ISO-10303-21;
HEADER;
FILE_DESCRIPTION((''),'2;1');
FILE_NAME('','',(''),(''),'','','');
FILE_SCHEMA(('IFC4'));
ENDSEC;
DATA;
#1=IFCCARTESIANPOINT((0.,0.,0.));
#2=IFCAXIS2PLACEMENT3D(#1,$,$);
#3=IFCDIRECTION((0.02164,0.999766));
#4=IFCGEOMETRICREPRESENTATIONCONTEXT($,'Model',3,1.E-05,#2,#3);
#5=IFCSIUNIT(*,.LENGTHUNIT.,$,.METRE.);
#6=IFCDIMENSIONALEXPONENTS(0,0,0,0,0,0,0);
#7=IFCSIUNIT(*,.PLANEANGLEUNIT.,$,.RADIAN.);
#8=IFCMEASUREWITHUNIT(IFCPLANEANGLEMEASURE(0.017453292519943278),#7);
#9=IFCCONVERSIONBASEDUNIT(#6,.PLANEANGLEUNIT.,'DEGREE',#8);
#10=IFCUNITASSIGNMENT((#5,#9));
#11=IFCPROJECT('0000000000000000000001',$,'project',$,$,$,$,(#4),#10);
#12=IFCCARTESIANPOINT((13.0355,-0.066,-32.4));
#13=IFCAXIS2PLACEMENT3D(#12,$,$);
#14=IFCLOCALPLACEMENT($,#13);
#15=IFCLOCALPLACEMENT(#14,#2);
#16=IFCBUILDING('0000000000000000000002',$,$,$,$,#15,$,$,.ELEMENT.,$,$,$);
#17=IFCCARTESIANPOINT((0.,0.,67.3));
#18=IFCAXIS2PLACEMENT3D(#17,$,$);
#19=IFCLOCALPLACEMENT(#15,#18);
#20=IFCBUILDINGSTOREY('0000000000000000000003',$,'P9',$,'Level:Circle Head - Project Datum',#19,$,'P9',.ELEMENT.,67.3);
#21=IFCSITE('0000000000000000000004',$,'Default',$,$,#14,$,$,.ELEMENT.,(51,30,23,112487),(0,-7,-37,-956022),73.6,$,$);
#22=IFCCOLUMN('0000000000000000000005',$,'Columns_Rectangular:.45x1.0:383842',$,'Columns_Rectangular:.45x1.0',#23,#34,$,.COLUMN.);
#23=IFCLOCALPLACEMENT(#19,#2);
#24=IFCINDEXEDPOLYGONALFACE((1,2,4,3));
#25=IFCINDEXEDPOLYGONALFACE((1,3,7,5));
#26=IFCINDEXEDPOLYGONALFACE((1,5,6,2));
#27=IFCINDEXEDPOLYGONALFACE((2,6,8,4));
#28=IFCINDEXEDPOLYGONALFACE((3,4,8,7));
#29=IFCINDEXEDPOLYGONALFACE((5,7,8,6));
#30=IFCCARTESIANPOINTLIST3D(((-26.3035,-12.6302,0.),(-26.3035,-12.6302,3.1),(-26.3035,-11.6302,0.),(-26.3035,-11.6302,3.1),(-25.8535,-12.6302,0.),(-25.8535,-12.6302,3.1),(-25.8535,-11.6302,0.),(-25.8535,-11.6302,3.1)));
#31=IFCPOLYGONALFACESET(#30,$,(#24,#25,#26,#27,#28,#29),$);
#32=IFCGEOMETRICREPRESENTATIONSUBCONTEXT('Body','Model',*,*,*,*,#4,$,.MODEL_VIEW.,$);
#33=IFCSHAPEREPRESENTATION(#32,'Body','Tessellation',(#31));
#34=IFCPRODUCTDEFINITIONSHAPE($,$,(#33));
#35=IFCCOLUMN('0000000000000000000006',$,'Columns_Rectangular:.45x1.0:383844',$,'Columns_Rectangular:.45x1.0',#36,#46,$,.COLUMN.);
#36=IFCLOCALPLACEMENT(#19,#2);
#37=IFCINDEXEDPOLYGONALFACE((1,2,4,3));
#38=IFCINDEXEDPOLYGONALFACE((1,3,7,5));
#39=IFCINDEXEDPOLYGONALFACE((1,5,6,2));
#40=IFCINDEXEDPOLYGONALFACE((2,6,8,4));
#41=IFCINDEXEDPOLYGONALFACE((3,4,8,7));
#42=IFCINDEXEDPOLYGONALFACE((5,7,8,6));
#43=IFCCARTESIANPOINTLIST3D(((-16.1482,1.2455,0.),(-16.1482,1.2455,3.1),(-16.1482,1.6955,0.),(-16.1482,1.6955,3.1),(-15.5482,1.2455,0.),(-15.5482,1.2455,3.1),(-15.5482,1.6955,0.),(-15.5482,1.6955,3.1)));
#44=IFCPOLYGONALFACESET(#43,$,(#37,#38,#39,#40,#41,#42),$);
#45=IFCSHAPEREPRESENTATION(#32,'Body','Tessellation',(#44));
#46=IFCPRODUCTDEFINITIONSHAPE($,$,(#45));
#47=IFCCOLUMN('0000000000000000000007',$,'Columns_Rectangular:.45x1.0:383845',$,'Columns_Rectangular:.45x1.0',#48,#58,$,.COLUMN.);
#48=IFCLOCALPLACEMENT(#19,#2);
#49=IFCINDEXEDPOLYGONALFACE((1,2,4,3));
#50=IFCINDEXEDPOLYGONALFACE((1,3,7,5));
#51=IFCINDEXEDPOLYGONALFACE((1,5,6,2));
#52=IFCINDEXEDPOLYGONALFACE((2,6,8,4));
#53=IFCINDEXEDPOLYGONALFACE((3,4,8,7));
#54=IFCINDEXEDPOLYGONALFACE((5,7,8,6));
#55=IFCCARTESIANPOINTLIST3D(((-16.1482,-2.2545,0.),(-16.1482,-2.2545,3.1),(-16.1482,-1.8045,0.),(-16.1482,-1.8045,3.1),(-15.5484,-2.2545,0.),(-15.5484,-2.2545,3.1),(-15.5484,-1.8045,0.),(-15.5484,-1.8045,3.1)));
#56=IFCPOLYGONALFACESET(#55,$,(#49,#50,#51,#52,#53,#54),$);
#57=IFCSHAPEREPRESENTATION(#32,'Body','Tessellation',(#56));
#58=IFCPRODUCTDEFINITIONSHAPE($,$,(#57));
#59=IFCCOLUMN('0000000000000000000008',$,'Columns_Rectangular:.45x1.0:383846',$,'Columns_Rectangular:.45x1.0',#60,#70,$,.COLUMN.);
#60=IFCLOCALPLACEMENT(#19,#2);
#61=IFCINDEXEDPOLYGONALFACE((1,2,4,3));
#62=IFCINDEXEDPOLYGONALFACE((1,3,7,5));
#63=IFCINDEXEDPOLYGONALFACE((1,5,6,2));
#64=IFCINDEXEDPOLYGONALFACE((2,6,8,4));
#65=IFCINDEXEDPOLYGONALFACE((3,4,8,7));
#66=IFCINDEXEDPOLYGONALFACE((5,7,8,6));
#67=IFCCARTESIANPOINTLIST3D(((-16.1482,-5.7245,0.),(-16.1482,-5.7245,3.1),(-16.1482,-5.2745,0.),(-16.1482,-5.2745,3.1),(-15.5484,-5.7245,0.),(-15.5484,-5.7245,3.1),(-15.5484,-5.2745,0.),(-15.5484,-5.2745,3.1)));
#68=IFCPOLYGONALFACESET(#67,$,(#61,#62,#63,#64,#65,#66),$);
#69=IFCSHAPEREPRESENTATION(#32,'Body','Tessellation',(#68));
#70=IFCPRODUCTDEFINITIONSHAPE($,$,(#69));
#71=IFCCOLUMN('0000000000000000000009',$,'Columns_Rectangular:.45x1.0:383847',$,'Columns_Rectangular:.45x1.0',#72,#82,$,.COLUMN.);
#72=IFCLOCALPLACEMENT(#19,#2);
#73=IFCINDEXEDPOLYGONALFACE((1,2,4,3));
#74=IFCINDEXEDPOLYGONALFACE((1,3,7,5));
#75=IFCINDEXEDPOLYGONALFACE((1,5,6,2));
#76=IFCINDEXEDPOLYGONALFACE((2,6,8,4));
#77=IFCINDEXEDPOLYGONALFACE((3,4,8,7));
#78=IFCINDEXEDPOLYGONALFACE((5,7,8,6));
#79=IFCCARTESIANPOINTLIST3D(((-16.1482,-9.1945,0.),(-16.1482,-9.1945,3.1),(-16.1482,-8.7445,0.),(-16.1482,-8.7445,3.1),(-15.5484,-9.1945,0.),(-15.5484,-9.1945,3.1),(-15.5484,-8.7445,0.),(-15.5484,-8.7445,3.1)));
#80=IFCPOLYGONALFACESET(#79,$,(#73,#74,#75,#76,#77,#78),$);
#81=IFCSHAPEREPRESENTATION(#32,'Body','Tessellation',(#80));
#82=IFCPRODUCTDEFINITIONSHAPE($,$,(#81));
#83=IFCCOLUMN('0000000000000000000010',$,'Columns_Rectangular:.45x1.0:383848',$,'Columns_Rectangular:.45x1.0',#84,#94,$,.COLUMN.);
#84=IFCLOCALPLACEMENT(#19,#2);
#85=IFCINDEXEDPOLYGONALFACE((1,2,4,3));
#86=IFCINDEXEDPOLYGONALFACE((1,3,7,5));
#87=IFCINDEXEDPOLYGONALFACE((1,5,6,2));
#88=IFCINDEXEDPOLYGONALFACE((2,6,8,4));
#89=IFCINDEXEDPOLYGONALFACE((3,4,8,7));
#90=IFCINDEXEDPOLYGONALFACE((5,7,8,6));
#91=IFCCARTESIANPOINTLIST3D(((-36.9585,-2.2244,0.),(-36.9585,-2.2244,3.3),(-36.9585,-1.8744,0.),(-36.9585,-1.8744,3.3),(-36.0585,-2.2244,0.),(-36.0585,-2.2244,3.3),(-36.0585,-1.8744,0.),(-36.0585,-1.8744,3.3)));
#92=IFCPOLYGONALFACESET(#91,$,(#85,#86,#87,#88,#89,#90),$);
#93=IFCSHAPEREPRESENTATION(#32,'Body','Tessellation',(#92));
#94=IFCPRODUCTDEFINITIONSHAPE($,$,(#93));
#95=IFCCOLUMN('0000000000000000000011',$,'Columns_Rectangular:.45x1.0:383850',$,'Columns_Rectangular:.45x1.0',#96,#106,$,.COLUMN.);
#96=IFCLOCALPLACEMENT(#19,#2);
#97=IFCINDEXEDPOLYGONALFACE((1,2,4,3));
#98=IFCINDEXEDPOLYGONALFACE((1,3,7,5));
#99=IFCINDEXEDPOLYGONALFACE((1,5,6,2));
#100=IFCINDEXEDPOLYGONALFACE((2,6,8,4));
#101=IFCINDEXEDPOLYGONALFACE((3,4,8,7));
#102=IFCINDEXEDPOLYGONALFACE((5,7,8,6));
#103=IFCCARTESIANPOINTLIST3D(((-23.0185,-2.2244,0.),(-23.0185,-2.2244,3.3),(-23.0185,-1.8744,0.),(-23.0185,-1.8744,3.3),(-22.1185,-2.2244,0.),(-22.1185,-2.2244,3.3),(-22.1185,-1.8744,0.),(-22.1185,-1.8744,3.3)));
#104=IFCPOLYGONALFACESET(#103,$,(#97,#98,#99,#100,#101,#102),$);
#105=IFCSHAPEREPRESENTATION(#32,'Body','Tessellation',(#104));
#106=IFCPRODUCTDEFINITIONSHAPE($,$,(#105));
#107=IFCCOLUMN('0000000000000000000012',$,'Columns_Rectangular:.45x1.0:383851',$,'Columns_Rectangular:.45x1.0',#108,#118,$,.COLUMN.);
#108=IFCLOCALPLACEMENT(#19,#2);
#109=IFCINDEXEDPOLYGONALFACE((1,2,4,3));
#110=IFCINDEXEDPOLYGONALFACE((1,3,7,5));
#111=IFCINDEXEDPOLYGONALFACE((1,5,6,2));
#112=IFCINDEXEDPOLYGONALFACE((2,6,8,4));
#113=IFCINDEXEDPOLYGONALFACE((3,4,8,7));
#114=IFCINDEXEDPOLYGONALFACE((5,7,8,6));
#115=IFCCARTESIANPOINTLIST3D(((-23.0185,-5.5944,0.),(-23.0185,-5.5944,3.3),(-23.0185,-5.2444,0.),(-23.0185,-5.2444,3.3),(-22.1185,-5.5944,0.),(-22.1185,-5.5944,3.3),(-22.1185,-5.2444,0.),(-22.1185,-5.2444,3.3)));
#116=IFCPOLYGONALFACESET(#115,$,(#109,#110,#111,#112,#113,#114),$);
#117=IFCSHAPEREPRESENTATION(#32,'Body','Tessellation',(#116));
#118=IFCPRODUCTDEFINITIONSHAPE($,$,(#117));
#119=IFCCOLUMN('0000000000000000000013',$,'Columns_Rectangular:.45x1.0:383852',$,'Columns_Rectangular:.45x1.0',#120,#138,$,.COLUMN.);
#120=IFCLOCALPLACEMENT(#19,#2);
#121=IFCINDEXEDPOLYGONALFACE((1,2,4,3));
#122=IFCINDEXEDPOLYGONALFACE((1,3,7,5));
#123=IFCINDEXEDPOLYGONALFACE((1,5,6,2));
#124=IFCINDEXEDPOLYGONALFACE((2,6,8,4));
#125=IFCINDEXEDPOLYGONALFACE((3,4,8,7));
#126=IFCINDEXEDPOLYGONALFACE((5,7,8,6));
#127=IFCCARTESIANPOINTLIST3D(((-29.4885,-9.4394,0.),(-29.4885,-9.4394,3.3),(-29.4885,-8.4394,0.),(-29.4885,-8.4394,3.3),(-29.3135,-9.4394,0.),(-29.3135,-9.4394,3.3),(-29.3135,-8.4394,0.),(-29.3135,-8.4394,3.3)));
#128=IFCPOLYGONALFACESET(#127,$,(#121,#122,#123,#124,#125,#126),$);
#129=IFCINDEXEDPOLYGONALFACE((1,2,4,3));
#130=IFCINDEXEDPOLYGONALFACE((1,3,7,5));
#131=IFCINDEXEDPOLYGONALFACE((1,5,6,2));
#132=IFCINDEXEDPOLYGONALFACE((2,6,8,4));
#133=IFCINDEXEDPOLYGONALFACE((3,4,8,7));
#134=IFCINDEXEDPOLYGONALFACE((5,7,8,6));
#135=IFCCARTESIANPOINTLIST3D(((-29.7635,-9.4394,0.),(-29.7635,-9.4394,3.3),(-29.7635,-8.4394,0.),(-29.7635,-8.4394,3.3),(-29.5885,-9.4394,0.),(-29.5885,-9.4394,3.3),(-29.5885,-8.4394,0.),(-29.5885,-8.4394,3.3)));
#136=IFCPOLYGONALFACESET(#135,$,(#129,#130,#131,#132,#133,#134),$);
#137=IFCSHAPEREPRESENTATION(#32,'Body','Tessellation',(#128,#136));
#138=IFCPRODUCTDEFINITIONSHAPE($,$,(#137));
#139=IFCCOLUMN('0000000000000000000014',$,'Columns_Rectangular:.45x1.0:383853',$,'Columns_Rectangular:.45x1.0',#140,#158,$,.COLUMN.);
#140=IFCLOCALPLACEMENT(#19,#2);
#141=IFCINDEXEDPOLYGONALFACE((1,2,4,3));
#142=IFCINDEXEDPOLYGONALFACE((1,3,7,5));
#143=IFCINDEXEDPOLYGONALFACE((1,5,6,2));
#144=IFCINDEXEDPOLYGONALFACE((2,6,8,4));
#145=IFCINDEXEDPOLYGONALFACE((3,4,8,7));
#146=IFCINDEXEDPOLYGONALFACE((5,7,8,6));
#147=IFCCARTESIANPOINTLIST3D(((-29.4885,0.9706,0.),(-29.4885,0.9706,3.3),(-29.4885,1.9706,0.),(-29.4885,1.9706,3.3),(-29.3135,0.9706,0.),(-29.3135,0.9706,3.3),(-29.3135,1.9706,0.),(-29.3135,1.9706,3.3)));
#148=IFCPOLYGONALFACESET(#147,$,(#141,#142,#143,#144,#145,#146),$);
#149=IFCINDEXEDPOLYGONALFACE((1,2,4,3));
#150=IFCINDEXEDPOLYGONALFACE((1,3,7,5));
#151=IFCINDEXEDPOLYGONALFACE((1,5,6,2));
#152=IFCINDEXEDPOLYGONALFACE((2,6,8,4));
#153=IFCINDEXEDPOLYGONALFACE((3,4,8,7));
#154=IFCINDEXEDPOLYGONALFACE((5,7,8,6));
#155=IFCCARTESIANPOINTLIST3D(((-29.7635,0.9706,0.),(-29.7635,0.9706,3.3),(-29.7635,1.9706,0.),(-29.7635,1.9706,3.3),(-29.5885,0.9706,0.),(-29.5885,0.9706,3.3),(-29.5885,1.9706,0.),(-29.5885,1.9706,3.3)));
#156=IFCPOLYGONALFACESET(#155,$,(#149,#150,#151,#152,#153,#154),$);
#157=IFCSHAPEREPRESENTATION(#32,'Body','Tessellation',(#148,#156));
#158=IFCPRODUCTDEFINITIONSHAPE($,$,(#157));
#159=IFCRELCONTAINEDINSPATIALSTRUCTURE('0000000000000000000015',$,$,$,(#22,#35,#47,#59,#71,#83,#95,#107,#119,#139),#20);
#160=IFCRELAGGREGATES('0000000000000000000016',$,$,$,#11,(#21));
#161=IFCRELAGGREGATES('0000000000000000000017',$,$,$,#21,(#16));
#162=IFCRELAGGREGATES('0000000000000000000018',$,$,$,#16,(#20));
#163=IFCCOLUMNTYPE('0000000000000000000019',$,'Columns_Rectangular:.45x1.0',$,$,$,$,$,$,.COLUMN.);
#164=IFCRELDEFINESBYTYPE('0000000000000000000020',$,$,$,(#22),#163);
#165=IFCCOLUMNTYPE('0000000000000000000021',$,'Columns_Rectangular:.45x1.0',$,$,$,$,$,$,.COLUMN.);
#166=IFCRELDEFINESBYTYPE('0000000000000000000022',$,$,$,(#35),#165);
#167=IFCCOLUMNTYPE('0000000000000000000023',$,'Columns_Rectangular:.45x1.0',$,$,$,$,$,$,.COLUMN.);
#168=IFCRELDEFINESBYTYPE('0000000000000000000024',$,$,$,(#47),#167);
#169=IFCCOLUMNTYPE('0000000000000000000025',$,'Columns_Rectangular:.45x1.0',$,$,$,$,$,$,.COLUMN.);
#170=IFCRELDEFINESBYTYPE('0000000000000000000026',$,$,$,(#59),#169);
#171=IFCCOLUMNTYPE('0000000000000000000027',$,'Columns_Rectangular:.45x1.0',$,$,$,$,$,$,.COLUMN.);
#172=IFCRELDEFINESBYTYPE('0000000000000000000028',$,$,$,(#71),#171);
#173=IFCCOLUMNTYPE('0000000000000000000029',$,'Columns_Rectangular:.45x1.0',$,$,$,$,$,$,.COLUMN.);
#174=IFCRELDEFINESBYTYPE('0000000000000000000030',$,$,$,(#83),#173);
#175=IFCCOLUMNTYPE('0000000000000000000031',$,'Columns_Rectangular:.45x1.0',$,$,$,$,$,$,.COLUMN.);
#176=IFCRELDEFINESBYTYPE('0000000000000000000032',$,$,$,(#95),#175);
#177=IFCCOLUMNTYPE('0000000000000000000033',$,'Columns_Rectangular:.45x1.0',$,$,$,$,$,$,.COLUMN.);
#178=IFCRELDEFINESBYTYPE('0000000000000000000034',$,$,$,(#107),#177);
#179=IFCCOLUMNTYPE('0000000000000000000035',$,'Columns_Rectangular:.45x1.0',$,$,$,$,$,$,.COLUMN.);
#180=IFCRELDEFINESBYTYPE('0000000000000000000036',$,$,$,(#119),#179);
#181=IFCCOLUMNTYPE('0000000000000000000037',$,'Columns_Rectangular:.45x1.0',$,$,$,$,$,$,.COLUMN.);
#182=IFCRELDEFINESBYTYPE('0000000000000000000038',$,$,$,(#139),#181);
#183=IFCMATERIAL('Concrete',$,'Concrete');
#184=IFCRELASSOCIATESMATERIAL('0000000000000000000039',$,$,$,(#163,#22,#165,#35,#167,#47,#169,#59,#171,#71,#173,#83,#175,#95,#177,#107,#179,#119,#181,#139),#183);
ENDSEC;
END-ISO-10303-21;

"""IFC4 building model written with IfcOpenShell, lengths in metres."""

from ifc_helpers import new_model, entity, si_unit, converted_unit, direction, frame, origin, place, context, subcontext, project, spatial, indexed_curve, outline, extrude, source, transform, mapped, material, type_object, type_shapes, element, save


model = new_model("IFC4")

# Units and contexts
model_context = context("Model", 3, precision=1e-05, world=origin(), true_north=direction((0.02164, 0.999766)))
body_context = subcontext(model_context, "Body", "Model", "MODEL_VIEW")
ifc_project = project(units=[si_unit("LENGTHUNIT", "METRE"), converted_unit("PLANEANGLEUNIT", "DEGREE", entity("IfcPlaneAngleMeasure", 0.017453292519943278), si_unit("PLANEANGLEUNIT", "RADIAN"), dimensions=[0, 0, 0, 0, 0, 0, 0])], contexts=[model_context])

# Site, building, storey
site_placement = place(None, frame((13.0355, -0.066, -32.4)))
site = spatial("IfcSite", under=ifc_project, at=site_placement, Name="Default", CompositionType="ELEMENT", RefLatitude=(51, 30, 23, 112487), RefLongitude=(0, -7, -37, -956022), RefElevation=73.6)
building_placement = place(site_placement, origin())
building = spatial("IfcBuilding", under=site, at=building_placement, CompositionType="ELEMENT")
storey_placement = place(building_placement, frame((0.0, 0.0, 67.3)))
storey = spatial("IfcBuildingStorey", under=building, at=storey_placement, Name="P9", ObjectType="Level:Circle Head - Project Datum", LongName="P9", CompositionType="ELEMENT", Elevation=67.3)

# Columns
ifc_material = material(Name="Concrete", Category="Concrete")
column_type_1 = type_object("IfcColumnType", Name="Columns_Rectangular:.45x1.0", PredefinedType="COLUMN", material=ifc_material)
shared_shape_1 = source(origin(), body_context, "Body", "SweptSolid", [
    extrude(outline(indexed_curve([(-0.5, -0.225), (0.5, -0.225), (0.5, 0.225), (-0.5, 0.225), (-0.5, -0.225)], self_intersect=False)), frame((-26.0785, -12.1302, 67.3), z_axis=(0.0, 0.0, 1.0), x_axis=(0.000011, 1.0, 0.0)), (0.0, 0.0, 1.0), 3.1),
])
type_shapes(column_type_1, [shared_shape_1])
column_1_placement = place(storey_placement, frame((0.0, 0.0, -67.3)))
element("IfcColumn", 1, at=column_1_placement, inside=storey, type_object=column_type_1, material=ifc_material, Name="Columns_Rectangular:.45x1.0:383842", ObjectType="Columns_Rectangular:.45x1.0", PredefinedType="COLUMN", context=body_context, shape_type="MappedRepresentation", body=[
    mapped(shared_shape_1, transform((0.0, 0.0, 0.0), scale=1.0)),
])
column_type_2 = type_object("IfcColumnType", Name="Columns_Rectangular:.45x1.0", PredefinedType="COLUMN", material=ifc_material)
shared_shape_2 = source(origin(), body_context, "Body", "SweptSolid", [
    extrude(outline(indexed_curve([(-0.3, -0.225), (0.3, -0.225), (0.3, 0.225), (-0.3, 0.225), (-0.3, -0.225)], self_intersect=False)), frame((-15.8482, 1.4705, 67.3), z_axis=(0.0, 0.0, 1.0), x_axis=(-1.0, 0.0, 0.0)), (0.0, 0.0, 1.0), 3.1),
])
type_shapes(column_type_2, [shared_shape_2])
column_2_placement = place(storey_placement, frame((0.0, 0.0, -67.3)))
element("IfcColumn", 2, at=column_2_placement, inside=storey, type_object=column_type_2, material=ifc_material, Name="Columns_Rectangular:.45x1.0:383844", ObjectType="Columns_Rectangular:.45x1.0", PredefinedType="COLUMN", context=body_context, shape_type="MappedRepresentation", body=[
    mapped(shared_shape_2, transform((0.0, 0.0, 0.0), scale=1.0)),
])
column_type_3 = type_object("IfcColumnType", Name="Columns_Rectangular:.45x1.0", PredefinedType="COLUMN", material=ifc_material)
shared_shape_3 = source(origin(), body_context, "Body", "SweptSolid", [
    extrude(outline(indexed_curve([(-0.2999, -0.225), (0.2999, -0.225), (0.2999, 0.225), (-0.2999, 0.225), (-0.2999, -0.225)], self_intersect=False)), frame((-15.8483, -2.0295, 67.3), z_axis=(0.0, 0.0, 1.0), x_axis=(-1.0, 0.0, 0.0)), (0.0, 0.0, 1.0), 3.1),
])
type_shapes(column_type_3, [shared_shape_3])
column_3_placement = place(storey_placement, frame((0.0, 0.0, -67.3)))
element("IfcColumn", 3, at=column_3_placement, inside=storey, type_object=column_type_3, material=ifc_material, Name="Columns_Rectangular:.45x1.0:383845", ObjectType="Columns_Rectangular:.45x1.0", PredefinedType="COLUMN", context=body_context, shape_type="MappedRepresentation", body=[
    mapped(shared_shape_3, transform((0.0, 0.0, 0.0), scale=1.0)),
])
column_type_4 = type_object("IfcColumnType", Name="Columns_Rectangular:.45x1.0", PredefinedType="COLUMN", material=ifc_material)
shared_shape_4 = source(origin(), body_context, "Body", "SweptSolid", [
    extrude(outline(indexed_curve([(-0.2999, -0.225), (0.2999, -0.225), (0.2999, 0.225), (-0.2999, 0.225), (-0.2999, -0.225)], self_intersect=False)), frame((-15.8483, -5.4995, 67.3), z_axis=(0.0, 0.0, 1.0), x_axis=(-1.0, 0.0, 0.0)), (0.0, 0.0, 1.0), 3.1),
])
type_shapes(column_type_4, [shared_shape_4])
column_4_placement = place(storey_placement, frame((0.0, 0.0, -67.3)))
element("IfcColumn", 4, at=column_4_placement, inside=storey, type_object=column_type_4, material=ifc_material, Name="Columns_Rectangular:.45x1.0:383846", ObjectType="Columns_Rectangular:.45x1.0", PredefinedType="COLUMN", context=body_context, shape_type="MappedRepresentation", body=[
    mapped(shared_shape_4, transform((0.0, 0.0, 0.0), scale=1.0)),
])
column_type_5 = type_object("IfcColumnType", Name="Columns_Rectangular:.45x1.0", PredefinedType="COLUMN", material=ifc_material)
shared_shape_5 = source(origin(), body_context, "Body", "SweptSolid", [
    extrude(outline(indexed_curve([(-0.2999, -0.225), (0.2999, -0.225), (0.2999, 0.225), (-0.2999, 0.225), (-0.2999, -0.225)], self_intersect=False)), frame((-15.8483, -8.9695, 67.3), z_axis=(0.0, 0.0, 1.0), x_axis=(-1.0, 0.0, 0.0)), (0.0, 0.0, 1.0), 3.1),
])
type_shapes(column_type_5, [shared_shape_5])
column_5_placement = place(storey_placement, frame((0.0, 0.0, -67.3)))
element("IfcColumn", 5, at=column_5_placement, inside=storey, type_object=column_type_5, material=ifc_material, Name="Columns_Rectangular:.45x1.0:383847", ObjectType="Columns_Rectangular:.45x1.0", PredefinedType="COLUMN", context=body_context, shape_type="MappedRepresentation", body=[
    mapped(shared_shape_5, transform((0.0, 0.0, 0.0), scale=1.0)),
])
column_type_6 = type_object("IfcColumnType", Name="Columns_Rectangular:.45x1.0", PredefinedType="COLUMN", material=ifc_material)
shared_shape_6 = source(origin(), body_context, "Body", "SweptSolid", [
    extrude(outline(indexed_curve([(-0.175, -0.45), (0.175, -0.45), (0.175, 0.45), (-0.175, 0.45), (-0.175, -0.45)], self_intersect=False)), frame((-36.5085, -2.0494, 67.3), z_axis=(0.0, 0.0, 1.0), x_axis=(0.0, 1.0, 0.0)), (0.0, 0.0, 1.0), 3.3),
])
type_shapes(column_type_6, [shared_shape_6])
column_6_placement = place(storey_placement, frame((0.0, 0.0, -67.3)))
element("IfcColumn", 6, at=column_6_placement, inside=storey, type_object=column_type_6, material=ifc_material, Name="Columns_Rectangular:.45x1.0:383848", ObjectType="Columns_Rectangular:.45x1.0", PredefinedType="COLUMN", context=body_context, shape_type="MappedRepresentation", body=[
    mapped(shared_shape_6, transform((0.0, 0.0, 0.0), scale=1.0)),
])
column_type_7 = type_object("IfcColumnType", Name="Columns_Rectangular:.45x1.0", PredefinedType="COLUMN", material=ifc_material)
shared_shape_7 = source(origin(), body_context, "Body", "SweptSolid", [
    extrude(outline(indexed_curve([(-0.175, -0.45), (0.175, -0.45), (0.175, 0.45), (-0.175, 0.45), (-0.175, -0.45)], self_intersect=False)), frame((-22.5685, -2.0494, 67.3), z_axis=(0.0, 0.0, 1.0), x_axis=(0.0, 1.0, 0.0)), (0.0, 0.0, 1.0), 3.3),
])
type_shapes(column_type_7, [shared_shape_7])
column_7_placement = place(storey_placement, frame((0.0, 0.0, -67.3)))
element("IfcColumn", 7, at=column_7_placement, inside=storey, type_object=column_type_7, material=ifc_material, Name="Columns_Rectangular:.45x1.0:383850", ObjectType="Columns_Rectangular:.45x1.0", PredefinedType="COLUMN", context=body_context, shape_type="MappedRepresentation", body=[
    mapped(shared_shape_7, transform((0.0, 0.0, 0.0), scale=1.0)),
])
column_type_8 = type_object("IfcColumnType", Name="Columns_Rectangular:.45x1.0", PredefinedType="COLUMN", material=ifc_material)
shared_shape_8 = source(origin(), body_context, "Body", "SweptSolid", [
    extrude(outline(indexed_curve([(-0.175, -0.45), (0.175, -0.45), (0.175, 0.45), (-0.175, 0.45), (-0.175, -0.45)], self_intersect=False)), frame((-22.5685, -5.4194, 67.3), z_axis=(0.0, 0.0, 1.0), x_axis=(0.0, -1.0, 0.0)), (0.0, 0.0, 1.0), 3.3),
])
type_shapes(column_type_8, [shared_shape_8])
column_8_placement = place(storey_placement, frame((0.0, 0.0, -67.3)))
element("IfcColumn", 8, at=column_8_placement, inside=storey, type_object=column_type_8, material=ifc_material, Name="Columns_Rectangular:.45x1.0:383851", ObjectType="Columns_Rectangular:.45x1.0", PredefinedType="COLUMN", context=body_context, shape_type="MappedRepresentation", body=[
    mapped(shared_shape_8, transform((0.0, 0.0, 0.0), scale=1.0)),
])
column_type_9 = type_object("IfcColumnType", Name="Columns_Rectangular:.45x1.0", PredefinedType="COLUMN", material=ifc_material)
shared_shape_9 = source(origin(), body_context, "Body", "SweptSolid", [
    extrude(outline(indexed_curve([(-0.0875, -0.5), (0.0875, -0.5), (0.0875, 0.5), (-0.0875, 0.5), (-0.0875, -0.5)], self_intersect=False)), frame((-29.401, -8.9394, 67.3), z_axis=(0.0, 0.0, 1.0), x_axis=(-1.0, 0.0, 0.0)), (0.0, 0.0, 1.0), 3.3),
    extrude(outline(indexed_curve([(-0.0875, -0.5), (0.0875, -0.5), (0.0875, 0.5), (-0.0875, 0.5), (-0.0875, -0.5)], self_intersect=False)), frame((-29.676, -8.9394, 67.3)), (0.0, 0.0, 1.0), 3.3),
])
type_shapes(column_type_9, [shared_shape_9])
column_9_placement = place(storey_placement, frame((0.0, 0.0, -67.3)))
element("IfcColumn", 9, at=column_9_placement, inside=storey, type_object=column_type_9, material=ifc_material, Name="Columns_Rectangular:.45x1.0:383852", ObjectType="Columns_Rectangular:.45x1.0", PredefinedType="COLUMN", context=body_context, shape_type="MappedRepresentation", body=[
    mapped(shared_shape_9, transform((0.0, 0.0, 0.0), scale=1.0)),
])
column_type_10 = type_object("IfcColumnType", Name="Columns_Rectangular:.45x1.0", PredefinedType="COLUMN", material=ifc_material)
shared_shape_10 = source(origin(), body_context, "Body", "SweptSolid", [
    extrude(outline(indexed_curve([(-0.0875, -0.5), (0.0875, -0.5), (0.0875, 0.5), (-0.0875, 0.5), (-0.0875, -0.5)], self_intersect=False)), frame((-29.401, 1.4706, 67.3), z_axis=(0.0, 0.0, 1.0), x_axis=(-1.0, 0.0, 0.0)), (0.0, 0.0, 1.0), 3.3),
    extrude(outline(indexed_curve([(-0.0875, -0.5), (0.0875, -0.5), (0.0875, 0.5), (-0.0875, 0.5), (-0.0875, -0.5)], self_intersect=False)), frame((-29.676, 1.4706, 67.3)), (0.0, 0.0, 1.0), 3.3),
])
type_shapes(column_type_10, [shared_shape_10])
column_10_placement = place(storey_placement, frame((0.0, 0.0, -67.3)))
element("IfcColumn", 10, at=column_10_placement, inside=storey, type_object=column_type_10, material=ifc_material, Name="Columns_Rectangular:.45x1.0:383853", ObjectType="Columns_Rectangular:.45x1.0", PredefinedType="COLUMN", context=body_context, shape_type="MappedRepresentation", body=[
    mapped(shared_shape_10, transform((0.0, 0.0, 0.0), scale=1.0)),
])

save(model, "model.ifc")
